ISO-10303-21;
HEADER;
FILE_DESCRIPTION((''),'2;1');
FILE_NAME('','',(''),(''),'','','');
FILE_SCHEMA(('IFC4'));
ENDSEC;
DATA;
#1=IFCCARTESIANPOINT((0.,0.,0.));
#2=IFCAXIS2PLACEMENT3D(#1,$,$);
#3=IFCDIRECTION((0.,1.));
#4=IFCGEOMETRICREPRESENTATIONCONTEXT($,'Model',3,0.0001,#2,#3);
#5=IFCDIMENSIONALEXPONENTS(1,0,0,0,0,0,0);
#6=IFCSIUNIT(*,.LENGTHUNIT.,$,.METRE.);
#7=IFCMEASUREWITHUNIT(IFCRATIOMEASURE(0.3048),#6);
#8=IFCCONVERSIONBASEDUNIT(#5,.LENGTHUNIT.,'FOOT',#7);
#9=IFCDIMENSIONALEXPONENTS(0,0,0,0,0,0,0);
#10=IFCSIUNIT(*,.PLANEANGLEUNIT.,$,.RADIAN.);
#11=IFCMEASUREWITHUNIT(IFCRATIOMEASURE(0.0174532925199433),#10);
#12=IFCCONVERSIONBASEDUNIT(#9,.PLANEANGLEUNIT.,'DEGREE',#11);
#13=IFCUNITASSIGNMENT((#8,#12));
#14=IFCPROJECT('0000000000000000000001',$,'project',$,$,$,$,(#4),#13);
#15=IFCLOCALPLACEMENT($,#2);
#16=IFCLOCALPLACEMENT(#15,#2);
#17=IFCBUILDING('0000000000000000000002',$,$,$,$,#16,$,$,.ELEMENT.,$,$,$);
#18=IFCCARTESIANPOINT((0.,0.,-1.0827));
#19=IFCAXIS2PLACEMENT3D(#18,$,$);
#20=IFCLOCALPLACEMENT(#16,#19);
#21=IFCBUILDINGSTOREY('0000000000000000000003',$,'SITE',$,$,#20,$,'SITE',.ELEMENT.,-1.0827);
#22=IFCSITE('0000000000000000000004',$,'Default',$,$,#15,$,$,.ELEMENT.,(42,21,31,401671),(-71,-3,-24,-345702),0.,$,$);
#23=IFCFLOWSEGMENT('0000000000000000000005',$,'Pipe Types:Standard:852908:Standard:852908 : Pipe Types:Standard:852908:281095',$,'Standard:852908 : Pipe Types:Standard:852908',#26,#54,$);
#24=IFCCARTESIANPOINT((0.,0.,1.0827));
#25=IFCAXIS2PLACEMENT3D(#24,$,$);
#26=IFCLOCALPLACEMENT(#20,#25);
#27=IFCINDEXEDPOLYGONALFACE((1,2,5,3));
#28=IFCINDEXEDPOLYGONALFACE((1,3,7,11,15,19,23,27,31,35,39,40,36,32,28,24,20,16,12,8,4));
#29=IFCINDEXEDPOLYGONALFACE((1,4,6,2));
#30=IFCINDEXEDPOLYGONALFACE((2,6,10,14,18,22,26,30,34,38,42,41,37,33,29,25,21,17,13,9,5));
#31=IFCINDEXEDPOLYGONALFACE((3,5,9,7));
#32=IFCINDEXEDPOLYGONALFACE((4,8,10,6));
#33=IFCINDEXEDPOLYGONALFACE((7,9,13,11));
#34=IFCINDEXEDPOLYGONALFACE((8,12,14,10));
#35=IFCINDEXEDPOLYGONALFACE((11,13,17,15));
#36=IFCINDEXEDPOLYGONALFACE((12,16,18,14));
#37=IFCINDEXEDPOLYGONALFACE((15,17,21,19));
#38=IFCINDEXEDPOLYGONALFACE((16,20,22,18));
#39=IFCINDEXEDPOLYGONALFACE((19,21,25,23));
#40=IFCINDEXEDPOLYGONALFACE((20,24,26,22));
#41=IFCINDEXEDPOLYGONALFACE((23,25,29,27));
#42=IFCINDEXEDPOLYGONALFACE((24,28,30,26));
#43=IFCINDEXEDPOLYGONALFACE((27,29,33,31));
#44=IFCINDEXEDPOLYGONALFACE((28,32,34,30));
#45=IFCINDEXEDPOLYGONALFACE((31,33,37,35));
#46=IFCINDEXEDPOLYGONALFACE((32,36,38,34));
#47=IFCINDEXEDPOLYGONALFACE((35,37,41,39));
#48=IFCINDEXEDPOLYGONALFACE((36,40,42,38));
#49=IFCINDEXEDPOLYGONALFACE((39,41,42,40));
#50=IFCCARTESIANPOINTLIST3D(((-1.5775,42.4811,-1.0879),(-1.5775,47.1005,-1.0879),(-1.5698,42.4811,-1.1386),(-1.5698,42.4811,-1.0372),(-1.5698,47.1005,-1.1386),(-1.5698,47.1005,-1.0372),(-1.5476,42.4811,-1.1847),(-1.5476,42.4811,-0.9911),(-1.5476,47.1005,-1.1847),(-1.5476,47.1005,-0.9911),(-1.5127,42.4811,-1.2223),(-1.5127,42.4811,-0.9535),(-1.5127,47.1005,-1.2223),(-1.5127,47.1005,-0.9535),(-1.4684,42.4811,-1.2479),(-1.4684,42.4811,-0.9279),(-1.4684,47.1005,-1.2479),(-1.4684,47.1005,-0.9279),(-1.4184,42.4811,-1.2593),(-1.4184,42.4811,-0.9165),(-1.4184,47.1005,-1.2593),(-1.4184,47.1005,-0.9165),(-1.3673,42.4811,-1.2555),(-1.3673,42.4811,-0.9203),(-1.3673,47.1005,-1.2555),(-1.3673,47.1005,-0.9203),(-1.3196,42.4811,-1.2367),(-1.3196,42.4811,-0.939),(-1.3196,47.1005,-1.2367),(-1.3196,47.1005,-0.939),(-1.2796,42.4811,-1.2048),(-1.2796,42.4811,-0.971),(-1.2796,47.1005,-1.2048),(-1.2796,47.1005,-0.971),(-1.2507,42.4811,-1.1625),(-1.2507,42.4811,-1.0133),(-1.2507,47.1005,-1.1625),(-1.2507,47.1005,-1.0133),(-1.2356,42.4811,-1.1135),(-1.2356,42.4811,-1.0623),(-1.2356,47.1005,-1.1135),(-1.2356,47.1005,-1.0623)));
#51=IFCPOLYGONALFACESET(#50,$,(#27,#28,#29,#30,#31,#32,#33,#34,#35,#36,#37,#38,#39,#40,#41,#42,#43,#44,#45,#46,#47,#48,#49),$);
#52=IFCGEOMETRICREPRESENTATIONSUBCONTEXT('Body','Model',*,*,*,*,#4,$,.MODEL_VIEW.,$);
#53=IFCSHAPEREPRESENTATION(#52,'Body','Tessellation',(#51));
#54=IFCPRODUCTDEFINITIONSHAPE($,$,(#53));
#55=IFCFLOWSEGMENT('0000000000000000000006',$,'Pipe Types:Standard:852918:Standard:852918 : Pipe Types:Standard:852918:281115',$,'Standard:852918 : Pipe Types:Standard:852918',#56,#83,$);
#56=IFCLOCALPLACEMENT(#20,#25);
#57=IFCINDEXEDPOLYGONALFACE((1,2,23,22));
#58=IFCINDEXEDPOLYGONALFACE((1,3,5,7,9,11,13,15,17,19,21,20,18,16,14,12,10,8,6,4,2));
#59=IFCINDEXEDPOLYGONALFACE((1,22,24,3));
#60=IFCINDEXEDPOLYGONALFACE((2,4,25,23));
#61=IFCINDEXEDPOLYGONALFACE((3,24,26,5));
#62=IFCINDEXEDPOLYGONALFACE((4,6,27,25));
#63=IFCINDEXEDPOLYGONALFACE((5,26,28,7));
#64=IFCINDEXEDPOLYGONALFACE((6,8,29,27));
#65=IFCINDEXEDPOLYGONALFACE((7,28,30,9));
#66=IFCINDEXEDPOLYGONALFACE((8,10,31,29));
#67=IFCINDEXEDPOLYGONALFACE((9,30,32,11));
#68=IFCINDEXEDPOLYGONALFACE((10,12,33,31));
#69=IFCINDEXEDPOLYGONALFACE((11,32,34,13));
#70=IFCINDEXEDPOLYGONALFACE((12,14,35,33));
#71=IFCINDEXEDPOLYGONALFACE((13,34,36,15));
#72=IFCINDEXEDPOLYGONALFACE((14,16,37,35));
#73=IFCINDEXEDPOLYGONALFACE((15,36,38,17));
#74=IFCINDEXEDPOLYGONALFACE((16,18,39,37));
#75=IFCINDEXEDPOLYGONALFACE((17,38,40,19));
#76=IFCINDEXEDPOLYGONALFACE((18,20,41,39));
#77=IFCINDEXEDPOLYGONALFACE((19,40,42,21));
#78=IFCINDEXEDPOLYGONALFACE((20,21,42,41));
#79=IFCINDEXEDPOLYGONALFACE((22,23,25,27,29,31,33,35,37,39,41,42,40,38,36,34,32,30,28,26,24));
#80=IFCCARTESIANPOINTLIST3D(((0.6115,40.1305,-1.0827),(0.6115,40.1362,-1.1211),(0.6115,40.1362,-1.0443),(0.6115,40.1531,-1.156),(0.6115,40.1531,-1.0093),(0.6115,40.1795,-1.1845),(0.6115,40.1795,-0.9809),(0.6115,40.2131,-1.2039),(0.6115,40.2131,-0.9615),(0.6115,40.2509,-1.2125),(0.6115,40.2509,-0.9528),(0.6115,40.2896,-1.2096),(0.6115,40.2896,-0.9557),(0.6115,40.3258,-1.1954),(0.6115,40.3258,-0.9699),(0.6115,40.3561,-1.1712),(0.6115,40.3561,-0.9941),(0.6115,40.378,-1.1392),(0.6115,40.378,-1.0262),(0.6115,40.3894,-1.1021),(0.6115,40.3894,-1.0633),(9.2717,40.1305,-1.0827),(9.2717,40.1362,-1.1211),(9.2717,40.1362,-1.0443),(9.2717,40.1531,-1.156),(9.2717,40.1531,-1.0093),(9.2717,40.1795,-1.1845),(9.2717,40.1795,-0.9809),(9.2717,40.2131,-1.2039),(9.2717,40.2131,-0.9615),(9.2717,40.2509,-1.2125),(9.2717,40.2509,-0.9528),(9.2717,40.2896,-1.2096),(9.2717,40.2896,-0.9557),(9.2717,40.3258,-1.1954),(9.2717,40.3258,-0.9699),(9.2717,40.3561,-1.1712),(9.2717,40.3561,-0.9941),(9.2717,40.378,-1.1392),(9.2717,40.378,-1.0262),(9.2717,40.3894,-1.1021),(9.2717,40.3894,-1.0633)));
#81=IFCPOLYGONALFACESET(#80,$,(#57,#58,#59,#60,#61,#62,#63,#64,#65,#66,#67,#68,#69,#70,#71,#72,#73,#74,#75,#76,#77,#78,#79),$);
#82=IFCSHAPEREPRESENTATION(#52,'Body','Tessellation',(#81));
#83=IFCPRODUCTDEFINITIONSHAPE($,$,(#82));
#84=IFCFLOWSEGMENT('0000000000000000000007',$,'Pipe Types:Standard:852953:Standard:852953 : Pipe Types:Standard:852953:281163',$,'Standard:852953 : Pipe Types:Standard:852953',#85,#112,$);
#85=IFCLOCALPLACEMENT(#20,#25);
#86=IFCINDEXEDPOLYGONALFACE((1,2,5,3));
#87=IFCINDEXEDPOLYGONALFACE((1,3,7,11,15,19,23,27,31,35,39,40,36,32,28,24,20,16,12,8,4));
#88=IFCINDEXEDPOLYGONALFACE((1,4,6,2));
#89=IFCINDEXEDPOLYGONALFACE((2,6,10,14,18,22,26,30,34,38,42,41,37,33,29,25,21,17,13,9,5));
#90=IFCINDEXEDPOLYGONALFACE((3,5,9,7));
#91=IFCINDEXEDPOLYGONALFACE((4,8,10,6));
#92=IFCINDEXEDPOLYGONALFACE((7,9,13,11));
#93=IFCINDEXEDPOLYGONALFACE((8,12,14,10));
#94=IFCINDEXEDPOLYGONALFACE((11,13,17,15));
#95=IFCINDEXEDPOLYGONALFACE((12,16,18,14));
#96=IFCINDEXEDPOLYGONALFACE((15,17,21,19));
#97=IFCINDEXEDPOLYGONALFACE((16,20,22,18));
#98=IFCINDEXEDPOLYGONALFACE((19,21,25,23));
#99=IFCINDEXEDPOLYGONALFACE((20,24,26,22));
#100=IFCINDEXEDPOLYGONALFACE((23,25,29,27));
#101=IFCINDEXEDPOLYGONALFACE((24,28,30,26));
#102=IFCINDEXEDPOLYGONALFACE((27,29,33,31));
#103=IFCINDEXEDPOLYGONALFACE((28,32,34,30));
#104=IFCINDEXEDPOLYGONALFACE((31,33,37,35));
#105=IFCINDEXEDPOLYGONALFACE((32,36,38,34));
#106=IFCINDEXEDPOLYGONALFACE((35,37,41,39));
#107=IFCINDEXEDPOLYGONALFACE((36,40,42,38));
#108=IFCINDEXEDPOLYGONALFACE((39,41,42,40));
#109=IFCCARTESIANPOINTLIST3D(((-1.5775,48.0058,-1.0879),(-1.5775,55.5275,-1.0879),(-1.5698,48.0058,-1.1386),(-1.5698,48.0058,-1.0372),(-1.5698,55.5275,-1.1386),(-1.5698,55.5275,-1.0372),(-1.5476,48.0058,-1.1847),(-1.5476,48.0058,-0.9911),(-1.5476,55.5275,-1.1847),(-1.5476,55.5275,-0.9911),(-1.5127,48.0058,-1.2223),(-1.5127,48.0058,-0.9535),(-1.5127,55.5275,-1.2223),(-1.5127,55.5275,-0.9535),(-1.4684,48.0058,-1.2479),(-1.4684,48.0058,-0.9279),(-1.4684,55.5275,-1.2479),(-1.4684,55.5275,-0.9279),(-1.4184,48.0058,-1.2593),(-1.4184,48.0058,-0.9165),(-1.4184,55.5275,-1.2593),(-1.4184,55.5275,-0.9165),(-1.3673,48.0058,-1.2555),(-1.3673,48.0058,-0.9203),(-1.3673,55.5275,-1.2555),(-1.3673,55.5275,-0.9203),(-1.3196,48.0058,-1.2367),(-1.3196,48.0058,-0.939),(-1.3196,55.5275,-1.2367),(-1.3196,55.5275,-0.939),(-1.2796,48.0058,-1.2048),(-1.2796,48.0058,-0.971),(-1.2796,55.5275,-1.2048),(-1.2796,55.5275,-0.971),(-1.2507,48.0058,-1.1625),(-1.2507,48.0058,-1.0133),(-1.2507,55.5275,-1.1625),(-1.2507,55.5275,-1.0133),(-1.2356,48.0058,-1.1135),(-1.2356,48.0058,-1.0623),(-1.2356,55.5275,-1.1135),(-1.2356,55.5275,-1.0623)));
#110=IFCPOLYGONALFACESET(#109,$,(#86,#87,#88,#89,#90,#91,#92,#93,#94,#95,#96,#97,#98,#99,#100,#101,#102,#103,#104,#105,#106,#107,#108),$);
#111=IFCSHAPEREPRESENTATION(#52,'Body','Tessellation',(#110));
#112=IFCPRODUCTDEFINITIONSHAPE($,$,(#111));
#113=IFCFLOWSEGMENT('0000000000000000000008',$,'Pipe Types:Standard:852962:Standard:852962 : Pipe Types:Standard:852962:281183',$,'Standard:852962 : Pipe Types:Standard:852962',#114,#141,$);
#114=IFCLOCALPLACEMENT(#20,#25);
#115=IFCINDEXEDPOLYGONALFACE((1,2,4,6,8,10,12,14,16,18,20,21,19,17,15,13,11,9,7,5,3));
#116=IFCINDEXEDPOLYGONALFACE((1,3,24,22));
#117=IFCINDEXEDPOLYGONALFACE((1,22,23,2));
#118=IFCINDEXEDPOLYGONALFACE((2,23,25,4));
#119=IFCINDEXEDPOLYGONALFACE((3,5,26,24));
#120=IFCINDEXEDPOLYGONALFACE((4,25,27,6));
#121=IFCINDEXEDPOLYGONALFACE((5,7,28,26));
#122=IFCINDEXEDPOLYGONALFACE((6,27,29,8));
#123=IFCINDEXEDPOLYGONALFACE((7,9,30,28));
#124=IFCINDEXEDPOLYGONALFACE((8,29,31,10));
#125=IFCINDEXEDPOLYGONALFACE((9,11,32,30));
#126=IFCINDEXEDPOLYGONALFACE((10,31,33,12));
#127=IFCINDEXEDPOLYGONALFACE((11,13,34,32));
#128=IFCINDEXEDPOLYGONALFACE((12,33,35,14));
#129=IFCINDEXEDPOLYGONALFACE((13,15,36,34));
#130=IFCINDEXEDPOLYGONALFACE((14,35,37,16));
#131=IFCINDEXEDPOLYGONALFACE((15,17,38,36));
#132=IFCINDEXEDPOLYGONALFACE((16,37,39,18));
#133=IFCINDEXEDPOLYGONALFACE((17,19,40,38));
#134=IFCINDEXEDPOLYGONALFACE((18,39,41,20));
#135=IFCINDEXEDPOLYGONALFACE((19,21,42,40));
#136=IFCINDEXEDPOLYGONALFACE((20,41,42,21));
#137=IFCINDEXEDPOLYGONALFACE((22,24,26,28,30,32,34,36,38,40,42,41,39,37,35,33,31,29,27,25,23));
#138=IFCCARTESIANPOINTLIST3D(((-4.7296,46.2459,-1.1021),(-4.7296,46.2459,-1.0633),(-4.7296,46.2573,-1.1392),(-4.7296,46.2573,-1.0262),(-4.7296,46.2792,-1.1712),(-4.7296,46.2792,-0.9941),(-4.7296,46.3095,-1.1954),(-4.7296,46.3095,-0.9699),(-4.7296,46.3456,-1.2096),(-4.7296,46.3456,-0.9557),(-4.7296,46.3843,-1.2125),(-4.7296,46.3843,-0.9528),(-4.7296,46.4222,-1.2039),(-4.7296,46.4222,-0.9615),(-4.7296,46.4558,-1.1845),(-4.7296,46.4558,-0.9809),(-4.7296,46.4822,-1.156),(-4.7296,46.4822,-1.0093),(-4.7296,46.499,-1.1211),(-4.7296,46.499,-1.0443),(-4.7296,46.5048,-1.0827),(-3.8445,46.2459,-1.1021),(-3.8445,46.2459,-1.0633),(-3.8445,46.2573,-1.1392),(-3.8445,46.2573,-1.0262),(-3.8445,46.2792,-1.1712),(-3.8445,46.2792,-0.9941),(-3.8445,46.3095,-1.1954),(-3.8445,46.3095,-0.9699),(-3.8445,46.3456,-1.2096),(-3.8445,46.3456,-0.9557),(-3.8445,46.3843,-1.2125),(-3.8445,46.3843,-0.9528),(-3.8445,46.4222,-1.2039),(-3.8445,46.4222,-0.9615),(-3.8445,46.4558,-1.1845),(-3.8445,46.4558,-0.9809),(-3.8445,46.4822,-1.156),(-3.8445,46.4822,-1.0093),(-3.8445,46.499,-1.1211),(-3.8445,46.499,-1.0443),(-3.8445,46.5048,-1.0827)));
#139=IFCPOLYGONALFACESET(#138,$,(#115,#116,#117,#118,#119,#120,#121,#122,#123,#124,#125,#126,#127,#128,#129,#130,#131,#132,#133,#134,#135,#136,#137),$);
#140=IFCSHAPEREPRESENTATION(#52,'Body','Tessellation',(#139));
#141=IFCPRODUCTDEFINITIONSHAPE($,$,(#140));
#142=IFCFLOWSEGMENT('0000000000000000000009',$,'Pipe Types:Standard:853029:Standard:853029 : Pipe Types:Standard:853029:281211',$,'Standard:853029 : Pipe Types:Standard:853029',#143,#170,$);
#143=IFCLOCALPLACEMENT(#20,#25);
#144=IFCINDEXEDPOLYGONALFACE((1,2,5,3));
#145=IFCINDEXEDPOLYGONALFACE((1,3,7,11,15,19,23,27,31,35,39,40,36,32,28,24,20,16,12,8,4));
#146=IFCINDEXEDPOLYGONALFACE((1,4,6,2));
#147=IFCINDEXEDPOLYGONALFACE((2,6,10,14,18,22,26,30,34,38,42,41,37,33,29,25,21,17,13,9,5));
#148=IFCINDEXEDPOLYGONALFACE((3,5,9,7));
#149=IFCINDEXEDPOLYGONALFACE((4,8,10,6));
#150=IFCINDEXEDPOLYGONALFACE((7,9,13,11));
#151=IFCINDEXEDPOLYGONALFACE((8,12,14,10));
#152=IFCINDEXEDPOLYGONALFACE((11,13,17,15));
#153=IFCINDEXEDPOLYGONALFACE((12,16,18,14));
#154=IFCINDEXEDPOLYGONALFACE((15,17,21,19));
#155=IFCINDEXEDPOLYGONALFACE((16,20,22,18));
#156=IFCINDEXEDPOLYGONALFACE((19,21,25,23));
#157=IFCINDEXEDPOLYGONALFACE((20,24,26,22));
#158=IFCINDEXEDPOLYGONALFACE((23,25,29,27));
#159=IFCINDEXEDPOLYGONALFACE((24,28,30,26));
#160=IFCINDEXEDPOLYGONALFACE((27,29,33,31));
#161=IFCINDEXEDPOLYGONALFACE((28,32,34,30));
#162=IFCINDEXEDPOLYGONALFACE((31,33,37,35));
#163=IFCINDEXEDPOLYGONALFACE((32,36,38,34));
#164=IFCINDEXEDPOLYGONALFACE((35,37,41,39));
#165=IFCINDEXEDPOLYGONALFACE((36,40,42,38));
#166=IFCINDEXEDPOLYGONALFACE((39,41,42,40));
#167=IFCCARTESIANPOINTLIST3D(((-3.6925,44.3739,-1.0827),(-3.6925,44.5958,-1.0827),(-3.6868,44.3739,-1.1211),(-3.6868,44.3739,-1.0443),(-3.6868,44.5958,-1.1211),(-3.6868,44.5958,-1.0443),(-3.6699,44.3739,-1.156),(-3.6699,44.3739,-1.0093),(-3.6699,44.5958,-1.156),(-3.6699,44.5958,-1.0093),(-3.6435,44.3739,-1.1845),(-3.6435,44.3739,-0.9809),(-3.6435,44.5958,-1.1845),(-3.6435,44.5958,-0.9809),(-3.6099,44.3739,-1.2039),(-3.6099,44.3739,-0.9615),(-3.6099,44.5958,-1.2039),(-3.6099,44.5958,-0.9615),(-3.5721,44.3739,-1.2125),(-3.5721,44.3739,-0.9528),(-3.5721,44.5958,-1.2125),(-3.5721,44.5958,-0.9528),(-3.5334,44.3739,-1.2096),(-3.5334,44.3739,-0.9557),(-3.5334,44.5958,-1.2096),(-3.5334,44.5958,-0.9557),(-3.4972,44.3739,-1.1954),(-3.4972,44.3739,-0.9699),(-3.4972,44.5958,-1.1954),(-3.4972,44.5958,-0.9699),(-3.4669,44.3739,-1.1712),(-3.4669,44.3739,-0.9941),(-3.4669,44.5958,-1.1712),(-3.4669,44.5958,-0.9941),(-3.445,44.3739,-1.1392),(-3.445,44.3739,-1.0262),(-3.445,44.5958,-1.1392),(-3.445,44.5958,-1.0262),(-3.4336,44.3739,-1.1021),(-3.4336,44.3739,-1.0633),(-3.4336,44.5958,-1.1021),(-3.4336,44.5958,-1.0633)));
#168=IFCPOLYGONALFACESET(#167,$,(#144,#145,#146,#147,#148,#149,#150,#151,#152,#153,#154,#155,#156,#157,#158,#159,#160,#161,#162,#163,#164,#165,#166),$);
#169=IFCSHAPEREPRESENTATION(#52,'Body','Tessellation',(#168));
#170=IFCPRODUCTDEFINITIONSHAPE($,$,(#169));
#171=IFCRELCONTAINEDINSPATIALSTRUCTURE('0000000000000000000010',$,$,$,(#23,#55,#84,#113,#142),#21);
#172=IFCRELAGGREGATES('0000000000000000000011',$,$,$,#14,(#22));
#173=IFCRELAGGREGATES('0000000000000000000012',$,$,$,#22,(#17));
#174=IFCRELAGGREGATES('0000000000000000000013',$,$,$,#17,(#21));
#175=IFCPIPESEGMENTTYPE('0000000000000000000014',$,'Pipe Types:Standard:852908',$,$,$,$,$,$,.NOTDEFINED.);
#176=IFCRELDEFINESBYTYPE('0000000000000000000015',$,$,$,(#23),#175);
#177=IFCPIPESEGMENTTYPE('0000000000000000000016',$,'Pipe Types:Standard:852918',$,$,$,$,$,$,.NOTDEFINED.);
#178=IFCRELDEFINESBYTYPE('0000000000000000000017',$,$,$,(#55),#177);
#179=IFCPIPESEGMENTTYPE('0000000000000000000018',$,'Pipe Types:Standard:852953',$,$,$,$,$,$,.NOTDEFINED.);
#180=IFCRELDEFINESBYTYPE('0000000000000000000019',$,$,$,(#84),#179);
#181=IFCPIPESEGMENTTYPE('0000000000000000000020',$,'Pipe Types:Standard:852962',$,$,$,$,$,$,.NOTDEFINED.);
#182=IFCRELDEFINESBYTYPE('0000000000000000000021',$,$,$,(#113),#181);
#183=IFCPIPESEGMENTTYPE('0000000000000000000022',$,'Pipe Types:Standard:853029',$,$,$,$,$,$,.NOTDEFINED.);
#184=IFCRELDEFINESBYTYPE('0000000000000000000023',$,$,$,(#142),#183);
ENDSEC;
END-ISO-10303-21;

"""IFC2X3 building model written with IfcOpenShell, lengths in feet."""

from ifc_helpers import new_model, entity, si_unit, converted_unit, direction, frame, frame_2d, origin, place, context, subcontext, project, spatial, circle, extrude, source, transform, mapped, type_object, type_shapes, element, save


model = new_model("IFC2X3")

# Units and contexts
model_context = context("Model", 3, precision=0.0001, world=origin(), true_north=direction((0.0, 1.0)))
body_context = subcontext(model_context, "Body", "Model", "MODEL_VIEW")
ifc_project = project(units=[converted_unit("LENGTHUNIT", "FOOT", entity("IfcRatioMeasure", 0.3048), si_unit("LENGTHUNIT", "METRE"), dimensions=[1, 0, 0, 0, 0, 0, 0]), converted_unit("PLANEANGLEUNIT", "DEGREE", entity("IfcRatioMeasure", 0.0174532925199433), si_unit("PLANEANGLEUNIT", "RADIAN"), dimensions=[0, 0, 0, 0, 0, 0, 0])], contexts=[model_context])

# Site, building, storey
site_placement = place(None, origin())
site = spatial("IfcSite", under=ifc_project, at=site_placement, Name="Default", CompositionType="ELEMENT", RefLatitude=(42, 21, 31, 401671), RefLongitude=(-71, -3, -24, -345702), RefElevation=0.0)
building_placement = place(site_placement, origin())
building = spatial("IfcBuilding", under=site, at=building_placement, CompositionType="ELEMENT")
storey_placement = place(building_placement, frame((0.0, 0.0, -1.0827)))
storey = spatial("IfcBuildingStorey", under=building, at=storey_placement, Name="SITE", LongName="SITE", CompositionType="ELEMENT", Elevation=-1.0827)

# Flow segments
pipe_segment_type_1 = type_object("IfcPipeSegmentType", Name="Pipe Types:Standard:852908", PredefinedType="NOTDEFINED")
shared_shape_1 = source(origin(), body_context, "Body", "SweptSolid", [
    extrude(circle(Radius=0.1719, at=frame_2d((0.0, 0.0), x_axis=(1.0, 0.0))), frame((-1.4056, 42.4811, -1.0879), z_axis=(0.0, 1.0, 0.0), x_axis=(-1.0, 0.0, 0.0)), (0.0, 0.0, 1.0), 4.6194),
])
type_shapes(pipe_segment_type_1, [shared_shape_1])
flow_segment_1_placement = place(storey_placement, frame((0.0, 0.0, 1.0827)))
element("IfcFlowSegment", 1, at=flow_segment_1_placement, inside=storey, type_object=pipe_segment_type_1, Name="Pipe Types:Standard:852908:Standard:852908 : Pipe Types:Standard:852908:281095", ObjectType="Standard:852908 : Pipe Types:Standard:852908", context=body_context, shape_type="MappedRepresentation", body=[
    mapped(shared_shape_1, transform((0.0, 0.0, 0.0), scale=1.0)),
])
pipe_segment_type_2 = type_object("IfcPipeSegmentType", Name="Pipe Types:Standard:852918", PredefinedType="NOTDEFINED")
shared_shape_2 = source(origin(), body_context, "Body", "SweptSolid", [
    extrude(circle(Radius=0.1302, at=frame_2d((0.0, 0.0), x_axis=(1.0, 0.0))), frame((0.6115, 40.2607, -1.0827), z_axis=(1.0, 0.0, 0.0), x_axis=(0.0, -1.0, 0.0)), (0.0, 0.0, 1.0), 8.6602),
])
type_shapes(pipe_segment_type_2, [shared_shape_2])
flow_segment_2_placement = place(storey_placement, frame((0.0, 0.0, 1.0827)))
element("IfcFlowSegment", 2, at=flow_segment_2_placement, inside=storey, type_object=pipe_segment_type_2, Name="Pipe Types:Standard:852918:Standard:852918 : Pipe Types:Standard:852918:281115", ObjectType="Standard:852918 : Pipe Types:Standard:852918", context=body_context, shape_type="MappedRepresentation", body=[
    mapped(shared_shape_2, transform((0.0, 0.0, 0.0), scale=1.0)),
])
pipe_segment_type_3 = type_object("IfcPipeSegmentType", Name="Pipe Types:Standard:852953", PredefinedType="NOTDEFINED")
shared_shape_3 = source(origin(), body_context, "Body", "SweptSolid", [
    extrude(circle(Radius=0.1719, at=frame_2d((0.0, 0.0), x_axis=(1.0, 0.0))), frame((-1.4056, 48.0058, -1.0879), z_axis=(0.0, 1.0, 0.0), x_axis=(-1.0, 0.0, 0.0)), (0.0, 0.0, 1.0), 7.5217),
])
type_shapes(pipe_segment_type_3, [shared_shape_3])
flow_segment_3_placement = place(storey_placement, frame((0.0, 0.0, 1.0827)))
element("IfcFlowSegment", 3, at=flow_segment_3_placement, inside=storey, type_object=pipe_segment_type_3, Name="Pipe Types:Standard:852953:Standard:852953 : Pipe Types:Standard:852953:281163", ObjectType="Standard:852953 : Pipe Types:Standard:852953", context=body_context, shape_type="MappedRepresentation", body=[
    mapped(shared_shape_3, transform((0.0, 0.0, 0.0), scale=1.0)),
])
pipe_segment_type_4 = type_object("IfcPipeSegmentType", Name="Pipe Types:Standard:852962", PredefinedType="NOTDEFINED")
shared_shape_4 = source(origin(), body_context, "Body", "SweptSolid", [
    extrude(circle(Radius=0.1302, at=frame_2d((0.0, 0.0), x_axis=(1.0, 0.0))), frame((-4.7296, 46.3746, -1.0827), z_axis=(1.0, 0.0, 0.0), x_axis=(0.0, 1.0, 0.0)), (0.0, 0.0, 1.0), 0.8851),
])
type_shapes(pipe_segment_type_4, [shared_shape_4])
flow_segment_4_placement = place(storey_placement, frame((0.0, 0.0, 1.0827)))
element("IfcFlowSegment", 4, at=flow_segment_4_placement, inside=storey, type_object=pipe_segment_type_4, Name="Pipe Types:Standard:852962:Standard:852962 : Pipe Types:Standard:852962:281183", ObjectType="Standard:852962 : Pipe Types:Standard:852962", context=body_context, shape_type="MappedRepresentation", body=[
    mapped(shared_shape_4, transform((0.0, 0.0, 0.0), scale=1.0)),
])
pipe_segment_type_5 = type_object("IfcPipeSegmentType", Name="Pipe Types:Standard:853029", PredefinedType="NOTDEFINED")
shared_shape_5 = source(origin(), body_context, "Body", "SweptSolid", [
    extrude(circle(Radius=0.1302, at=frame_2d((0.0, 0.0), x_axis=(1.0, 0.0))), frame((-3.5623, 44.3739, -1.0827), z_axis=(0.0, 1.0, 0.0), x_axis=(-1.0, 0.0, 0.0)), (0.0, 0.0, 1.0), 0.2219),
])
type_shapes(pipe_segment_type_5, [shared_shape_5])
flow_segment_5_placement = place(storey_placement, frame((0.0, 0.0, 1.0827)))
element("IfcFlowSegment", 5, at=flow_segment_5_placement, inside=storey, type_object=pipe_segment_type_5, Name="Pipe Types:Standard:853029:Standard:853029 : Pipe Types:Standard:853029:281211", ObjectType="Standard:853029 : Pipe Types:Standard:853029", context=body_context, shape_type="MappedRepresentation", body=[
    mapped(shared_shape_5, transform((0.0, 0.0, 0.0), scale=1.0)),
])

save(model, "model.ifc")
